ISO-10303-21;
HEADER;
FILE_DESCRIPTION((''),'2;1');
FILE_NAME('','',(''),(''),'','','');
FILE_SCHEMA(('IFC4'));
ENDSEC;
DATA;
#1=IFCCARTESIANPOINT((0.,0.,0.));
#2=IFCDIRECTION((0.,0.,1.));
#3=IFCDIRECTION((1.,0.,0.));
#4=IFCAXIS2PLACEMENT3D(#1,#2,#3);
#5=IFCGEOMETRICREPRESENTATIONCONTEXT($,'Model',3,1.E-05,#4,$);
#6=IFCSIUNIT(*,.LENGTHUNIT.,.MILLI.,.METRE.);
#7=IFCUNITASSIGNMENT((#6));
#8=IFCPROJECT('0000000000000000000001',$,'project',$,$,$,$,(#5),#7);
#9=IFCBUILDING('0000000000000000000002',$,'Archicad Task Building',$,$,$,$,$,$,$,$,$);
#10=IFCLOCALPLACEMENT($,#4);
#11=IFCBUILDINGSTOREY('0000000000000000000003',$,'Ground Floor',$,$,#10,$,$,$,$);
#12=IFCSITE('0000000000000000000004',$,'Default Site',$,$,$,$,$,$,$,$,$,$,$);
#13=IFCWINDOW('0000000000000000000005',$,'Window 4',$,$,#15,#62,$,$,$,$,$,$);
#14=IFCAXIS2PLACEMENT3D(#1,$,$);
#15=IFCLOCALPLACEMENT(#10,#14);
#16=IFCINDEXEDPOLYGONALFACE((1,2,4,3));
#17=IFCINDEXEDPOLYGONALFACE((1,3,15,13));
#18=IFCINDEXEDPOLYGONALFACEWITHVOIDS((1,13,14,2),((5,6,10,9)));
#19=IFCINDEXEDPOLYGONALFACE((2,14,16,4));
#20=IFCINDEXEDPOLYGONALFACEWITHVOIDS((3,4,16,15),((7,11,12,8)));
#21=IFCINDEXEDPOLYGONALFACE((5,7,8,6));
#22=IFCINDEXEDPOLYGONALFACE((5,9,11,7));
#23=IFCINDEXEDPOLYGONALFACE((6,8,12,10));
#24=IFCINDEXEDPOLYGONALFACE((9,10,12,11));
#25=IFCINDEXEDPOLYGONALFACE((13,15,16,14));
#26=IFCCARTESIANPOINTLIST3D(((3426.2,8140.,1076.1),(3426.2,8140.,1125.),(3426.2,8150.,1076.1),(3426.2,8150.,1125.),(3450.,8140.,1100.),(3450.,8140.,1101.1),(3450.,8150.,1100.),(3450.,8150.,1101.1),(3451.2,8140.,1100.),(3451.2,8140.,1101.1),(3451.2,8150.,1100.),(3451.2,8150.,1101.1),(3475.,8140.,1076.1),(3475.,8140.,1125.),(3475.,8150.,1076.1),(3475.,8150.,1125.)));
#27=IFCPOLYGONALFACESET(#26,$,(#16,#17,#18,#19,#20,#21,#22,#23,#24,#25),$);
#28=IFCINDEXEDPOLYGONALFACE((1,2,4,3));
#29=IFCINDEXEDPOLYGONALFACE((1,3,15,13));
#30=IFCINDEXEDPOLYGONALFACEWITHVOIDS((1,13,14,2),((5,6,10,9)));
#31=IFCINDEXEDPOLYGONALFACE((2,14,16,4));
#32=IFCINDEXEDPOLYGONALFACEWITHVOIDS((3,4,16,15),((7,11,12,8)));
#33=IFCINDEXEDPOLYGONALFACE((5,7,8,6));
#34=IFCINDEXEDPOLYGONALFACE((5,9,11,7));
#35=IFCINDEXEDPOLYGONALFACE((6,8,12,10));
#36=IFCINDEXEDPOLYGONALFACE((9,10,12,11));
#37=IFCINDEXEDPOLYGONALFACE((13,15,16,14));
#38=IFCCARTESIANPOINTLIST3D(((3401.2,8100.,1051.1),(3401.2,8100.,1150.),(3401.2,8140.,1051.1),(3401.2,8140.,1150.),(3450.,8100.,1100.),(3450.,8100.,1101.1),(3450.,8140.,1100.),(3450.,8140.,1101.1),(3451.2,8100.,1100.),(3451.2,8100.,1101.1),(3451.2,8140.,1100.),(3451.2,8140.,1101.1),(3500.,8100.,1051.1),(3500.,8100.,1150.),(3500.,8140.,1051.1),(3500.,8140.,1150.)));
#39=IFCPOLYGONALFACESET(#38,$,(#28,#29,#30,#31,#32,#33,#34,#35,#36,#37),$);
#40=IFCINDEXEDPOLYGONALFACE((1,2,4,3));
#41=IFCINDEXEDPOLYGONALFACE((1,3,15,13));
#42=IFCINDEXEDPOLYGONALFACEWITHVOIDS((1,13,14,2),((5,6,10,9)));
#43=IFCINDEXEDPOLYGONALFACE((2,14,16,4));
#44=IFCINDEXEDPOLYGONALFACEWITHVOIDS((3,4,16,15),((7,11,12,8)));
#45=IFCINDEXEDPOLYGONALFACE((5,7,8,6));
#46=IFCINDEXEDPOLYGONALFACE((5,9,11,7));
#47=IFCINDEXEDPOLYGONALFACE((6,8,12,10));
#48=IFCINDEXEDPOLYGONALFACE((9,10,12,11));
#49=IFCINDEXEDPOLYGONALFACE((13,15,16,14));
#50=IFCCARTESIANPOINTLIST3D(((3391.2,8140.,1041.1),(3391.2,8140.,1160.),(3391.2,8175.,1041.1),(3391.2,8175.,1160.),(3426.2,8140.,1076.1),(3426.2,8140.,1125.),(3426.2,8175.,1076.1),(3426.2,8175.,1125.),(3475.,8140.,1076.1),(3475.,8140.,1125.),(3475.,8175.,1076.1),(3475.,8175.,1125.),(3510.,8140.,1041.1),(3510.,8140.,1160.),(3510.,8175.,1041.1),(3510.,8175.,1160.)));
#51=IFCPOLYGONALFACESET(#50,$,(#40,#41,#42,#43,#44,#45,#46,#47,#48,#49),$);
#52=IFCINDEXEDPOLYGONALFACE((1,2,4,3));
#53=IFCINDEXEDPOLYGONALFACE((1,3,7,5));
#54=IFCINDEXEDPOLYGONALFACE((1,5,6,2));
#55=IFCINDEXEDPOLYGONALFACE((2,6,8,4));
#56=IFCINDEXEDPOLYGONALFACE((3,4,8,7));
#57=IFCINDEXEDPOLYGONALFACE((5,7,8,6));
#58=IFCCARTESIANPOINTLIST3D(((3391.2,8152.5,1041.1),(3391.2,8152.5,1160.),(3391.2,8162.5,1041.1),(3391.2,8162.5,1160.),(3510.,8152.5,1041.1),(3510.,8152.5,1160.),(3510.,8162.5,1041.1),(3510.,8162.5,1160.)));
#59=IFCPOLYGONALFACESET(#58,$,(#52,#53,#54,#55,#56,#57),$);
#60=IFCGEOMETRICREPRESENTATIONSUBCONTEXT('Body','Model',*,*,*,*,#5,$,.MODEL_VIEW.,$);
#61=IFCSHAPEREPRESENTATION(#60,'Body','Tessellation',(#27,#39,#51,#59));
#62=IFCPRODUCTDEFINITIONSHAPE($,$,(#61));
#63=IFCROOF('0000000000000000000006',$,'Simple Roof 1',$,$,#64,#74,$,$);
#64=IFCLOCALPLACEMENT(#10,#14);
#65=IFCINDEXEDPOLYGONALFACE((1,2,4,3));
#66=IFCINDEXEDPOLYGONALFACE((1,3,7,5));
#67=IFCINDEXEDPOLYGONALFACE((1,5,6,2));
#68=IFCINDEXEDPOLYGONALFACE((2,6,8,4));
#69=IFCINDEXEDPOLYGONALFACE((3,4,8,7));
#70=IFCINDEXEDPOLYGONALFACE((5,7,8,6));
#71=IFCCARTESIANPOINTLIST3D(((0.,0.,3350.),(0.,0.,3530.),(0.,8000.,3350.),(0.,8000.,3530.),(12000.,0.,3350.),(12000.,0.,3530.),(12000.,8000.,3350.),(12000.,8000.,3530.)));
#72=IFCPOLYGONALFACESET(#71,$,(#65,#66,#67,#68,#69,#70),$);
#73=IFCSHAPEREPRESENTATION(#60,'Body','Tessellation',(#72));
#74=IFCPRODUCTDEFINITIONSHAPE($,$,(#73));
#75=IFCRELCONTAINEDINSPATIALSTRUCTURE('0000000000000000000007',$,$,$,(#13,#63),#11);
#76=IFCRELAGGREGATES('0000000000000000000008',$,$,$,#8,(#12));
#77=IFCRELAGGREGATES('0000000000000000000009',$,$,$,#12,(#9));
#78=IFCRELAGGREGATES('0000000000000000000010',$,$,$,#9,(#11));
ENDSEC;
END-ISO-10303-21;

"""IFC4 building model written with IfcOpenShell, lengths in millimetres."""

from ifc_helpers import new_model, si_unit, frame, origin_with_axes, place, context, subcontext, project, spatial, line, indexed_curve, outline, extrude, element, save


model = new_model("IFC4")

# Units and contexts
model_context = context("Model", 3, precision=1e-05, world=origin_with_axes())
body_context = subcontext(model_context, "Body", "Model", "MODEL_VIEW")
ifc_project = project(units=[si_unit("LENGTHUNIT", "METRE", prefix="MILLI")], contexts=[model_context])

# Site, building, storey
site = spatial("IfcSite", under=ifc_project, Name="Default Site")
building = spatial("IfcBuilding", under=site, Name="Archicad Task Building")
storey_placement = place(None, origin_with_axes())
storey = spatial("IfcBuildingStorey", under=building, at=storey_placement, Name="Ground Floor")

# Window
for number, where, z_axis, x_axis, name in (
    (1, (3450.0, 8050.0, 1100.0), (0.0, 0.0, 1.0), (1.0, 0.0, 0.0), "Window 4"),
):
    element("IfcWindow", number, at=place(storey_placement, frame(where, z_axis=z_axis, x_axis=x_axis)), inside=storey, Name=name, context=body_context, shape_type="SweptSolid", body=[
        extrude(outline(indexed_curve([(0.0, 0.0), (1.2, 0.0), (1.2, 1.1), (0.0, 1.1)], segments=[line(1, 2, 3, 4, 1)]), holes=[indexed_curve([(25.0, 25.0), (-23.8, 25.0), (-23.8, -23.9), (25.0, -23.9)], segments=[line(1, 2, 3, 4, 1)])]), frame((0.0, 90.0, 0.0), z_axis=(0.0, -1.0, 0.0), x_axis=(1.0, 0.0, 0.0)), (0.0, 0.0, -1.0), 10.0),
        extrude(outline(indexed_curve([(0.0, 0.0), (1.2, 0.0), (1.2, 1.1), (0.0, 1.1)], segments=[line(1, 2, 3, 4, 1)]), holes=[indexed_curve([(50.0, 50.0), (-48.8, 50.0), (-48.8, -48.9), (50.0, -48.9)], segments=[line(1, 2, 3, 4, 1)])]), frame((0.0, 50.0, 0.0), z_axis=(0.0, -1.0, 0.0), x_axis=(1.0, 0.0, 0.0)), (0.0, 0.0, -1.0), 40.0),
        extrude(outline(indexed_curve([(0.0, 0.0), (-48.8, 0.0), (-48.8, -48.9), (0.0, -48.9)], segments=[line(1, 2, 3, 4, 1)]), holes=[indexed_curve([(35.0, 35.0), (-83.8, 35.0), (-83.8, -83.9), (35.0, -83.9)], segments=[line(1, 2, 3, 4, 1)])]), frame((25.0, 90.0, 25.0), z_axis=(0.0, -1.0, 0.0), x_axis=(1.0, 0.0, 0.0)), (0.0, 0.0, -1.0), 35.0),
        extrude(outline(indexed_curve([(35.0, 35.0), (-83.8, 35.0), (-83.8, -83.9), (35.0, -83.9)], segments=[line(1, 2, 3, 4, 1)])), frame((25.0, 102.5, 25.0), z_axis=(0.0, -1.0, 0.0), x_axis=(1.0, 0.0, 0.0)), (0.0, 0.0, -1.0), 10.0),
    ])

# Roof
roof_placement = place(storey_placement, frame((0.0, 0.0, 3350.0), z_axis=(0.0, 0.0, 1.0), x_axis=(1.0, 0.0, 0.0)))
element("IfcRoof", 2, at=roof_placement, inside=storey, Name="Simple Roof 1", context=body_context, shape_type="SweptSolid", body=[
    extrude(outline(indexed_curve([(0.0, 0.0), (12000.0, 0.0), (12000.0, 8000.0), (0.0, 8000.0), (0.0, 0.0)])), None, (0.0, 0.0, 1.0), 180.0),
])

save(model, "model.ifc")
